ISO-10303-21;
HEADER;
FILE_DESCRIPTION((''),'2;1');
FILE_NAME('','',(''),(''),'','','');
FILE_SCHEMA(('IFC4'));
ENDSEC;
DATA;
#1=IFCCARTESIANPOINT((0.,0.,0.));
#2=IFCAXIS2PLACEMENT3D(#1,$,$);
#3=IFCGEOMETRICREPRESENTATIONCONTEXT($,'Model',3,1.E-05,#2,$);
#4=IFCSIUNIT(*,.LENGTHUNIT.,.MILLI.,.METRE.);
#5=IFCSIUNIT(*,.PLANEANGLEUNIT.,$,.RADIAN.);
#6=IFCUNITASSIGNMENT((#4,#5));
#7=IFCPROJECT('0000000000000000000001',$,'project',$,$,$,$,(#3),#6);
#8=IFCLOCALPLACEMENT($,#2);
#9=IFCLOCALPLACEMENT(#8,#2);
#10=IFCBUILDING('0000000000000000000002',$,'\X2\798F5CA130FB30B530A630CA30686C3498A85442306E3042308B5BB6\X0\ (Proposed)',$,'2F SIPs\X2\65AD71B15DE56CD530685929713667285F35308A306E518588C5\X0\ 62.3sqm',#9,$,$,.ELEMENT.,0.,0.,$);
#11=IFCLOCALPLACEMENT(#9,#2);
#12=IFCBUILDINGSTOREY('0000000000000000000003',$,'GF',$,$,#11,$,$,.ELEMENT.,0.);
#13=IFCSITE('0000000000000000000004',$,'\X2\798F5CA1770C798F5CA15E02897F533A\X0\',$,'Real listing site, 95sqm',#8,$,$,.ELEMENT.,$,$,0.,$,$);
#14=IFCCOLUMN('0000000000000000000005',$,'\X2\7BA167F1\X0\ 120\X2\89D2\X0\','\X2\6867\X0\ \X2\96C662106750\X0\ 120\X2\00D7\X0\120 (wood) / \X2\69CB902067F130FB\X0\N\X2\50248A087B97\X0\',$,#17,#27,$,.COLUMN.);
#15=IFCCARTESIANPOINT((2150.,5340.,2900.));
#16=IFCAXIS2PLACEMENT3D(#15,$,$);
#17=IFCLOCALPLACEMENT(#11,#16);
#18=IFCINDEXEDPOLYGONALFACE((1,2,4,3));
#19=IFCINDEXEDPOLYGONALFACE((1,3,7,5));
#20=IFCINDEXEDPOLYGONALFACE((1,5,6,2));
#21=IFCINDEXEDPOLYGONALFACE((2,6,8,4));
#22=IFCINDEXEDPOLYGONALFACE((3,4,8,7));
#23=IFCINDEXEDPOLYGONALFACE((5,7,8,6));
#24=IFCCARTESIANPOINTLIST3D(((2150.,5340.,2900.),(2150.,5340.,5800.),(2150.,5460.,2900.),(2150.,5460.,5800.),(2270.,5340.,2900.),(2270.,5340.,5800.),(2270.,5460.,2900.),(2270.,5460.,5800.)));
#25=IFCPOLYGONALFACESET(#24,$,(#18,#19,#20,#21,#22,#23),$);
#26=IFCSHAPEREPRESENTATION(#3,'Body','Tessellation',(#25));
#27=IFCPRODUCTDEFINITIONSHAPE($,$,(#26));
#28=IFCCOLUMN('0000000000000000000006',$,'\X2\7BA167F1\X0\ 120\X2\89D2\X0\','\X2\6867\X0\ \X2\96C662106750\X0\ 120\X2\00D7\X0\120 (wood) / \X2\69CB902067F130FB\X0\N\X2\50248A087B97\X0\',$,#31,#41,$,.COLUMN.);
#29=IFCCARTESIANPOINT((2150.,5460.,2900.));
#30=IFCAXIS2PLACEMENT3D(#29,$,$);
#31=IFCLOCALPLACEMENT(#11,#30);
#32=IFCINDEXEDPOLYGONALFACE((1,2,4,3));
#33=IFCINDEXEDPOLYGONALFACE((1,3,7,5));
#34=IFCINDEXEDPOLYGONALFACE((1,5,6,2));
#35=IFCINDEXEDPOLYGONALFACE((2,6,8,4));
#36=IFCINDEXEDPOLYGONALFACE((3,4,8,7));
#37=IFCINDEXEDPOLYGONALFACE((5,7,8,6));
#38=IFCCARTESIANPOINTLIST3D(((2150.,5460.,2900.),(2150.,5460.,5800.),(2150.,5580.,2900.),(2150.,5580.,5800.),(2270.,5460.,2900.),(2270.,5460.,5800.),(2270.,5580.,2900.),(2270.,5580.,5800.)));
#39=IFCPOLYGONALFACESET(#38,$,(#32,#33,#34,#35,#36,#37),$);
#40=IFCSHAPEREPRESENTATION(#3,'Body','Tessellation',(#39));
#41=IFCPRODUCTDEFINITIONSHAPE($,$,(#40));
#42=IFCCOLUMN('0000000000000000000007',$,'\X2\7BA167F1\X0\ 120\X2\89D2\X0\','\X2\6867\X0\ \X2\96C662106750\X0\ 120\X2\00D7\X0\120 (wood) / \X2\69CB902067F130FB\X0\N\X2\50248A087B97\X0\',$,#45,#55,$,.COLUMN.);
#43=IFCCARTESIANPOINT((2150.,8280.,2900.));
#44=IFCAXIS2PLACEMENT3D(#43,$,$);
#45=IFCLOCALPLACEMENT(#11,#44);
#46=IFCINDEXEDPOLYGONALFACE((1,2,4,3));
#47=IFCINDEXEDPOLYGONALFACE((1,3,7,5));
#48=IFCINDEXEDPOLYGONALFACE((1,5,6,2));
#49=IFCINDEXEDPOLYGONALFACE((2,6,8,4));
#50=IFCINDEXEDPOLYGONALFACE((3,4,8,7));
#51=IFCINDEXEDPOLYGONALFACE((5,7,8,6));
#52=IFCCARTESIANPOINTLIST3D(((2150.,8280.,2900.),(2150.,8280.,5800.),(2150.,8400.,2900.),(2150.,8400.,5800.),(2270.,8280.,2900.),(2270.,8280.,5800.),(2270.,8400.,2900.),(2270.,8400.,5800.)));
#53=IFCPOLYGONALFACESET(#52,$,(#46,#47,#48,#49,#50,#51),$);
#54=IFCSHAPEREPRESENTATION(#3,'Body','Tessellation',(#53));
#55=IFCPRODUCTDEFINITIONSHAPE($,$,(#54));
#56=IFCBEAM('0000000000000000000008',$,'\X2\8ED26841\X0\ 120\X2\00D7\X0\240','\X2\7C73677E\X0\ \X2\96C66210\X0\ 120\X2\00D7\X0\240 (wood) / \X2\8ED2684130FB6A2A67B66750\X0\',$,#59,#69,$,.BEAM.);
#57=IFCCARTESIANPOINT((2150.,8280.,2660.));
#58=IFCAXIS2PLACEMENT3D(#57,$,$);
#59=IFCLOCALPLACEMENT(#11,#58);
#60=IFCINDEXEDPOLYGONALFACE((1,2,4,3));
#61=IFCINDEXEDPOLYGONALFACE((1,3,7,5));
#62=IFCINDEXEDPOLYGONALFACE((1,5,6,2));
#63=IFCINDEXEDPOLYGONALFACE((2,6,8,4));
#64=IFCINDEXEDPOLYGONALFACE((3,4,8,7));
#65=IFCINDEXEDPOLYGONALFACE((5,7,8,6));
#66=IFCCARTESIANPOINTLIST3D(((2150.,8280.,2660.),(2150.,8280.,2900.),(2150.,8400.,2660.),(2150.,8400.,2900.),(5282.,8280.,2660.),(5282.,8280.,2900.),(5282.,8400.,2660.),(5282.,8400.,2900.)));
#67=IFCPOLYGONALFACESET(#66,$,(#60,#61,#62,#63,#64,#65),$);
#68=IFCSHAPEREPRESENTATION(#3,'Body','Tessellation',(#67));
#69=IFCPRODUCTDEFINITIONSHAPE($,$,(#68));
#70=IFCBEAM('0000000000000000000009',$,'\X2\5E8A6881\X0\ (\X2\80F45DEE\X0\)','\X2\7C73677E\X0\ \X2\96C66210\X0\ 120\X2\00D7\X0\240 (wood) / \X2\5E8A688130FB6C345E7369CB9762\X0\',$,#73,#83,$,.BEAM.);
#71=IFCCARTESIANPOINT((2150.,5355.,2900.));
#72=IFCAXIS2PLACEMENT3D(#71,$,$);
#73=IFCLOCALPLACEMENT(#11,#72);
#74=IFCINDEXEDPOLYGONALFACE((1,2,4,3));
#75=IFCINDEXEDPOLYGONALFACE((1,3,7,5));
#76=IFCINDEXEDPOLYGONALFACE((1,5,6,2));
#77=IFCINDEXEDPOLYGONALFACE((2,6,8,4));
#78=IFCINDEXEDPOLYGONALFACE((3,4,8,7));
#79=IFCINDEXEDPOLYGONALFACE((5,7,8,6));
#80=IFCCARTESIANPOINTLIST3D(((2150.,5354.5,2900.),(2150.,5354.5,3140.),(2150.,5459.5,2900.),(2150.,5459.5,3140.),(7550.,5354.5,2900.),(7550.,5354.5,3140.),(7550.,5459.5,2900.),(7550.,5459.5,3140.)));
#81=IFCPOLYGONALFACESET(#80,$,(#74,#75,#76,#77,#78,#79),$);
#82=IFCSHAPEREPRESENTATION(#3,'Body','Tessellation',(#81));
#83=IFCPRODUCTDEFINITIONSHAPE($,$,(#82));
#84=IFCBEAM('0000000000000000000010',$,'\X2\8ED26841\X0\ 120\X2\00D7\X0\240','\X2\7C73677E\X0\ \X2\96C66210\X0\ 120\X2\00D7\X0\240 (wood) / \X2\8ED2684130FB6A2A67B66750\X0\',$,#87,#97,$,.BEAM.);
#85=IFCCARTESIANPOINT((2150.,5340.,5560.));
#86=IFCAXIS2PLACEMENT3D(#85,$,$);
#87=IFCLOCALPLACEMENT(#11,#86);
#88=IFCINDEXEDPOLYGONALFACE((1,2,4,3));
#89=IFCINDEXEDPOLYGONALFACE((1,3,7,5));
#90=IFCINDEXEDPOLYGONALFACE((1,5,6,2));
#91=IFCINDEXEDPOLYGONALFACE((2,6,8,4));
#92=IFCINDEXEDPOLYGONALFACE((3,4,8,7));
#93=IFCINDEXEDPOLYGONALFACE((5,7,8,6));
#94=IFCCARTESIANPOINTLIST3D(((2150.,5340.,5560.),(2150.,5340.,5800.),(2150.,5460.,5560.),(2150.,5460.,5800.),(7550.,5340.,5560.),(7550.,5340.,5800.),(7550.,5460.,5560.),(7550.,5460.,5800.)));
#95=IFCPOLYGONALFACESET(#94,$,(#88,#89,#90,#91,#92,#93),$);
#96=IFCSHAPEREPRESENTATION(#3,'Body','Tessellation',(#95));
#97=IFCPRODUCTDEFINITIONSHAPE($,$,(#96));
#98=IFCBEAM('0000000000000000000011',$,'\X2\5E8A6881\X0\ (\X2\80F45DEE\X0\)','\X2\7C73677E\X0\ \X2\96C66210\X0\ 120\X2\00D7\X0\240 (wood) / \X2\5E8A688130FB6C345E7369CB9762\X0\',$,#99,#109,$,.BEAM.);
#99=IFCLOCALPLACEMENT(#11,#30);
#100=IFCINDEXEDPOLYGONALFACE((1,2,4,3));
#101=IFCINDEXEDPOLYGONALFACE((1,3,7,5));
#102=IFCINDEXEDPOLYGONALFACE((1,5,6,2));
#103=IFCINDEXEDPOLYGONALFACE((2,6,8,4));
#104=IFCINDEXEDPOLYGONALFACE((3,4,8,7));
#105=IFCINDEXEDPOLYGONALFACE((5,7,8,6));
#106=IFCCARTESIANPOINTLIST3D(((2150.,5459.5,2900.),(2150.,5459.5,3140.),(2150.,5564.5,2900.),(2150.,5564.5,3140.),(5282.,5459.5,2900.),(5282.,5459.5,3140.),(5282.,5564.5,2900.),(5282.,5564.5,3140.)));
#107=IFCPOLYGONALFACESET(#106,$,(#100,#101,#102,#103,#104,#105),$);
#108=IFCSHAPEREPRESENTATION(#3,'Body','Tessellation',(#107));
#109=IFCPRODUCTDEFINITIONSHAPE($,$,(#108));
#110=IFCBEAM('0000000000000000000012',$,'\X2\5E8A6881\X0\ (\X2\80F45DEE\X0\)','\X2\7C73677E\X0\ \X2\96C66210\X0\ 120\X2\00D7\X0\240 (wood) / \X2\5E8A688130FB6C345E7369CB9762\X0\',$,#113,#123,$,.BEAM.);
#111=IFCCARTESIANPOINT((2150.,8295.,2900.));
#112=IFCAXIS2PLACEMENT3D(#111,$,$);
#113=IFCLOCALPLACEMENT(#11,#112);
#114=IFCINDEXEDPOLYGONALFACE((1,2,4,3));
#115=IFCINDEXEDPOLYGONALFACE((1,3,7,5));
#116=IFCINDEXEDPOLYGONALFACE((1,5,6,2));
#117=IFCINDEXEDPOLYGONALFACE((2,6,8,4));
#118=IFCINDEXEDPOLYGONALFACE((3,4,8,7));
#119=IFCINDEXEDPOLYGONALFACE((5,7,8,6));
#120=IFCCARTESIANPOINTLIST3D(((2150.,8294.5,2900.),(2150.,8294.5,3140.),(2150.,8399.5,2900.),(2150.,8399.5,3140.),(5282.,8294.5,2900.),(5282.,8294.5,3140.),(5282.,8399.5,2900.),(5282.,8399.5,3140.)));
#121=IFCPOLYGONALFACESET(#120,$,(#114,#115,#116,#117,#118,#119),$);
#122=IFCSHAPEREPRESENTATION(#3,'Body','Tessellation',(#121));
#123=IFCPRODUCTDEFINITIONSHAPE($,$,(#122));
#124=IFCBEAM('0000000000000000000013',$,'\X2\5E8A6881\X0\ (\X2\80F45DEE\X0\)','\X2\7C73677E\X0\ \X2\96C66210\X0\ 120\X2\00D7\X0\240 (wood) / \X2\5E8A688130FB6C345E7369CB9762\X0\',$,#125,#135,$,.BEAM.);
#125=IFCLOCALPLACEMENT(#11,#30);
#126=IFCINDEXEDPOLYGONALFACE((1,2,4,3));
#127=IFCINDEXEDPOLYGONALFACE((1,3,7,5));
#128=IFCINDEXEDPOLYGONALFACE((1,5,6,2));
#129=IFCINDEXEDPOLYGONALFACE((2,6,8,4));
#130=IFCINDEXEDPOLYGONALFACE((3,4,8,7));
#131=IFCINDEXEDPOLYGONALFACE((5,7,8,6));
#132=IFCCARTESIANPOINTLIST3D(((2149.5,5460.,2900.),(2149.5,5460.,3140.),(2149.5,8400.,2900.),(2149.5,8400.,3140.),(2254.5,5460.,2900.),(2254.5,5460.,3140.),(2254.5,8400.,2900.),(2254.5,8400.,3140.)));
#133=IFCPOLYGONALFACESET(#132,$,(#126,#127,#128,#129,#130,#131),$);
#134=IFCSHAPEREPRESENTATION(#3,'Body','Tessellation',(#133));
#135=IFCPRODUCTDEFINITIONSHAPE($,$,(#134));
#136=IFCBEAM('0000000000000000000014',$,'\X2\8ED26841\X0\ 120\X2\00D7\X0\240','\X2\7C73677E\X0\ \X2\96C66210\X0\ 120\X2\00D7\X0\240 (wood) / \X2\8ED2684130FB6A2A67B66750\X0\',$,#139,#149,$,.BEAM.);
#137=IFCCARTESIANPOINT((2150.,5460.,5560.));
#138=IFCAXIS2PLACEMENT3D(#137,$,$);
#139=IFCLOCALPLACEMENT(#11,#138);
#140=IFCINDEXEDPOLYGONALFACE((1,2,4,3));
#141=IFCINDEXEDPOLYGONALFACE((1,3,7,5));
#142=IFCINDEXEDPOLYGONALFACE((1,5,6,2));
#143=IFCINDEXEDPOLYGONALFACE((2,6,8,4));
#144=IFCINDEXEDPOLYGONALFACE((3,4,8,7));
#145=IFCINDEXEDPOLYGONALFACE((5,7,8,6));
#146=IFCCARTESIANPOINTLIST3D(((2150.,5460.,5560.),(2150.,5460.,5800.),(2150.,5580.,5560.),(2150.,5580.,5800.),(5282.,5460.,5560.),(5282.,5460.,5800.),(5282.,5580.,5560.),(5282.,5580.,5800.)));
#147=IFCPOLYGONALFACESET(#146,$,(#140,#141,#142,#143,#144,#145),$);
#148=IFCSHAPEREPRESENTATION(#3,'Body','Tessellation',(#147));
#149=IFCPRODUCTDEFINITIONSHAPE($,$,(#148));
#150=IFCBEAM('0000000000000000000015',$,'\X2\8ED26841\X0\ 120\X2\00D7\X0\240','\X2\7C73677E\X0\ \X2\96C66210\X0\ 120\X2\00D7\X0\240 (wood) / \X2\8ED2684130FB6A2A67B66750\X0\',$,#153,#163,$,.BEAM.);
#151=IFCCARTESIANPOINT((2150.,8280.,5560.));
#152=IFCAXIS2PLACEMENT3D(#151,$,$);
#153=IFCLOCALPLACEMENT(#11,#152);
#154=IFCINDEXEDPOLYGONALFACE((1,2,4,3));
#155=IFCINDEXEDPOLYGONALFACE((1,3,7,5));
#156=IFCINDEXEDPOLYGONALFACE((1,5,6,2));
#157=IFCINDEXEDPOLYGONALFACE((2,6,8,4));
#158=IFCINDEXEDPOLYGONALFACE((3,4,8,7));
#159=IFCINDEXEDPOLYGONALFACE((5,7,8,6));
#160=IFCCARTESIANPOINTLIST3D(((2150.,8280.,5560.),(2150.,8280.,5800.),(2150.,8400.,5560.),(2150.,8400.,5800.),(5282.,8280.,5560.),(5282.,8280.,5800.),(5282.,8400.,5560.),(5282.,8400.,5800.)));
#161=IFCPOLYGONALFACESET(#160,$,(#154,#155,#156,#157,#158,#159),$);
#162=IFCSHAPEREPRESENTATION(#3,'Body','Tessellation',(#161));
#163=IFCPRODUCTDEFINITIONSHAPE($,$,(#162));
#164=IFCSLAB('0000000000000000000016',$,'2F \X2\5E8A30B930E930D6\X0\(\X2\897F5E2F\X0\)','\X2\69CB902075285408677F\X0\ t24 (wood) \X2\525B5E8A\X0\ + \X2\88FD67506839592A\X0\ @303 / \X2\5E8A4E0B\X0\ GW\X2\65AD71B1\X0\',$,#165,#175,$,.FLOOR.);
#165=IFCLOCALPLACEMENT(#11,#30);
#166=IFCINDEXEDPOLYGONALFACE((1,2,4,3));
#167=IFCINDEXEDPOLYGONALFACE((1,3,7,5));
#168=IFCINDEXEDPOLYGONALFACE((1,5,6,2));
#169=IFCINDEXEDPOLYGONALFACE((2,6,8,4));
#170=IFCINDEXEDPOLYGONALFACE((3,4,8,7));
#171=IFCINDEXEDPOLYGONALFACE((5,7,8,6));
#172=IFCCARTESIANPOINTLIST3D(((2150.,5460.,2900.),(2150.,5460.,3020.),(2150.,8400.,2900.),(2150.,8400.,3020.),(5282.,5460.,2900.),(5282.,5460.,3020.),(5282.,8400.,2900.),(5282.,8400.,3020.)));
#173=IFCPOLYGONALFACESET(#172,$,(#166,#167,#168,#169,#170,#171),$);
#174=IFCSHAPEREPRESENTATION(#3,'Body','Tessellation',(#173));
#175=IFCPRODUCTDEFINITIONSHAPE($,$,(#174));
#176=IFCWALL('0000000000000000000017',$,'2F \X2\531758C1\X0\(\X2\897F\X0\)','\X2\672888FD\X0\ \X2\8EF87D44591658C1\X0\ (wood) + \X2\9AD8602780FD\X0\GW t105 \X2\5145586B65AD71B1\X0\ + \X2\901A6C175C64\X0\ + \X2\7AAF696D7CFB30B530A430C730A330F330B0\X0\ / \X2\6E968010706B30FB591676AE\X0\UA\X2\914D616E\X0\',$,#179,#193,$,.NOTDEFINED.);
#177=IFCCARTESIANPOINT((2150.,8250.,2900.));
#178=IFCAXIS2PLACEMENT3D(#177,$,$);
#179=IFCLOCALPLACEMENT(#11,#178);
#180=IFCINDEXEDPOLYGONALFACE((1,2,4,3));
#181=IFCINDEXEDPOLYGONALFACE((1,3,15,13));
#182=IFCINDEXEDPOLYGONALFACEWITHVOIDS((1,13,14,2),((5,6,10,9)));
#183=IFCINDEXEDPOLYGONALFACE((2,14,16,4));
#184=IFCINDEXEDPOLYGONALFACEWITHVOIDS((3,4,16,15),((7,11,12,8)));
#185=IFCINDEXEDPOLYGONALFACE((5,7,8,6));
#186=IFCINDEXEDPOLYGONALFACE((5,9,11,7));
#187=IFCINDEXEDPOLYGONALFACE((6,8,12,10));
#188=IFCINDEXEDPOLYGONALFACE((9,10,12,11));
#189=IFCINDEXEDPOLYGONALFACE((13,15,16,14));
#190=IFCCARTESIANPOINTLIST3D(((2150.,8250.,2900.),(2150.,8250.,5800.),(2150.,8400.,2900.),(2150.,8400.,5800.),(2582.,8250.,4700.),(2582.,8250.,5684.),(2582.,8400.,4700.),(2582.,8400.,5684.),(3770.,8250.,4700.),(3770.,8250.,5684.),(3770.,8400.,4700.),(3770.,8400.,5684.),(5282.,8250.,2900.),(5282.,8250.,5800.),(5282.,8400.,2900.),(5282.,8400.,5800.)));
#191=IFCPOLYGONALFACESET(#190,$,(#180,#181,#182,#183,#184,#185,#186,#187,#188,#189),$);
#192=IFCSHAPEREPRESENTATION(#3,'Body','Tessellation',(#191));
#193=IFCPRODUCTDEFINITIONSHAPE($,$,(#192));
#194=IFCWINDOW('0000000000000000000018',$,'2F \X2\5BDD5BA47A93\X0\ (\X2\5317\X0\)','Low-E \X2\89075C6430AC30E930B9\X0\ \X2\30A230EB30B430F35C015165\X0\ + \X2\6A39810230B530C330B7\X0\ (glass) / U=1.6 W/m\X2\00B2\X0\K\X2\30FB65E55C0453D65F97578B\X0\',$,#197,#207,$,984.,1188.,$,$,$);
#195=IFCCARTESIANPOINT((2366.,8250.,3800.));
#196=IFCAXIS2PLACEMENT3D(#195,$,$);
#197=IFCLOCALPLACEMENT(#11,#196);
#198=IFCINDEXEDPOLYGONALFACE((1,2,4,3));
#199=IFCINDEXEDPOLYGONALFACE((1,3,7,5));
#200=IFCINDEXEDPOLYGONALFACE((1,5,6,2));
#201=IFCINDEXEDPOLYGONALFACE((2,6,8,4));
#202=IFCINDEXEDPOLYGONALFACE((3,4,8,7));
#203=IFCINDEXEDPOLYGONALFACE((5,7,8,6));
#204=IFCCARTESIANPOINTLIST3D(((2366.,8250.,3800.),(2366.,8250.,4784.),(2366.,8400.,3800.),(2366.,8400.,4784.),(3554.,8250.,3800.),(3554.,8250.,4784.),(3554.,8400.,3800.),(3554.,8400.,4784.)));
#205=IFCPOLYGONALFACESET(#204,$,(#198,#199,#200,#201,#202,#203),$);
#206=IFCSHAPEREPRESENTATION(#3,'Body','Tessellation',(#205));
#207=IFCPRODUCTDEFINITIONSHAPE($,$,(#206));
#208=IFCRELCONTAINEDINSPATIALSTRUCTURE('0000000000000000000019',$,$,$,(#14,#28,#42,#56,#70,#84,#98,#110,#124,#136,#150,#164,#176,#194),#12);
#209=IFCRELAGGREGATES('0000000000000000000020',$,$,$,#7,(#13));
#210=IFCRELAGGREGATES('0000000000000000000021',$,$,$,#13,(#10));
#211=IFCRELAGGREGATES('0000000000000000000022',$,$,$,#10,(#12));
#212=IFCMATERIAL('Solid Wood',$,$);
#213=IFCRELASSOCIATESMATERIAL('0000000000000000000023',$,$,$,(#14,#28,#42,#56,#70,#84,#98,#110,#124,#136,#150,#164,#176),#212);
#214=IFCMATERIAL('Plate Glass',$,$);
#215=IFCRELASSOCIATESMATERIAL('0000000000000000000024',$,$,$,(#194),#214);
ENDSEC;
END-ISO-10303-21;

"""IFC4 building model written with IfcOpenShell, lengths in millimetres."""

from ifc_helpers import new_model, si_unit, frame, frame_2d, origin, place, context, project, spatial, rectangle, extrude, material, element, fill, save


model = new_model("IFC4")

# Units and contexts
model_context = context("Model", 3, precision=1e-05, world=origin())
ifc_project = project(units=[si_unit("LENGTHUNIT", "METRE", prefix="MILLI"), si_unit("PLANEANGLEUNIT", "RADIAN")], contexts=[model_context])

# Site, building, storey
site_placement = place(None, origin())
site = spatial("IfcSite", under=ifc_project, at=site_placement, Name="福岡県福岡市西区", ObjectType="Real listing site, 95sqm", CompositionType="ELEMENT", RefElevation=0.0)
building_placement = place(site_placement, origin())
building = spatial("IfcBuilding", under=site, at=building_placement, Name="福岡・サウナと水風呂のある家 (Proposed)", ObjectType="2F SIPs断熱工法と天然木張りの内装 62.3sqm", CompositionType="ELEMENT", ElevationOfRefHeight=0.0, ElevationOfTerrain=0.0)
storey_placement = place(building_placement, origin())
storey = spatial("IfcBuildingStorey", under=building, at=storey_placement, Name="GF", CompositionType="ELEMENT", Elevation=0.0)

# Columns
ifc_material_1 = material(Name="Solid Wood")
column_1_placement = place(storey_placement, frame((2150.0, 5340.0, 2900.0)))
element("IfcColumn", 1, at=column_1_placement, inside=storey, material=ifc_material_1, Name="管柱 120角", Description="桧 集成材 120×120 (wood) / 構造柱・N値計算", PredefinedType="COLUMN", context=model_context, shape_type="SweptSolid", body=[
    extrude(rectangle(XDim=120.0, YDim=120.0, at=frame_2d((60.0, 60.0))), frame((2150.0, 5340.0, 2900.0)), (0.0, 0.0, 1.0), 2900.0),
])
column_2_placement = place(storey_placement, frame((2150.0, 5460.0, 2900.0)))
element("IfcColumn", 2, at=column_2_placement, inside=storey, material=ifc_material_1, Name="管柱 120角", Description="桧 集成材 120×120 (wood) / 構造柱・N値計算", PredefinedType="COLUMN", context=model_context, shape_type="SweptSolid", body=[
    extrude(rectangle(XDim=120.0, YDim=120.0, at=frame_2d((60.0, 60.0))), frame((2150.0, 5460.0, 2900.0)), (0.0, 0.0, 1.0), 2900.0),
])
column_3_placement = place(storey_placement, frame((2150.0, 8280.0, 2900.0)))
element("IfcColumn", 3, at=column_3_placement, inside=storey, material=ifc_material_1, Name="管柱 120角", Description="桧 集成材 120×120 (wood) / 構造柱・N値計算", PredefinedType="COLUMN", context=model_context, shape_type="SweptSolid", body=[
    extrude(rectangle(XDim=120.0, YDim=120.0, at=frame_2d((60.0, 60.0))), frame((2150.0, 8280.0, 2900.0)), (0.0, 0.0, 1.0), 2900.0),
])

# Beams
beam_1_placement = place(storey_placement, frame((2150.0, 8280.0, 2660.0)))
element("IfcBeam", 4, at=beam_1_placement, inside=storey, material=ifc_material_1, Name="軒桁 120×240", Description="米松 集成 120×240 (wood) / 軒桁・横架材", PredefinedType="BEAM", context=model_context, shape_type="SweptSolid", body=[
    extrude(rectangle(XDim=3132.0, YDim=120.0, at=frame_2d((1566.0, 60.0))), frame((2150.0, 8280.0, 2660.0)), (0.0, 0.0, 1.0), 240.0),
])
beam_2_placement = place(storey_placement, frame((2150.0, 5355.0, 2900.0)))
element("IfcBeam", 5, at=beam_2_placement, inside=storey, material=ifc_material_1, Name="床梁 (胴差)", Description="米松 集成 120×240 (wood) / 床梁・水平構面", PredefinedType="BEAM", context=model_context, shape_type="SweptSolid", body=[
    extrude(rectangle(XDim=5400.0, YDim=105.0, at=frame_2d((2700.0, 52.0))), frame((2150.0, 5355.0, 2900.0)), (0.0, 0.0, 1.0), 240.0),
])
beam_3_placement = place(storey_placement, frame((2150.0, 5340.0, 5560.0)))
element("IfcBeam", 6, at=beam_3_placement, inside=storey, material=ifc_material_1, Name="軒桁 120×240", Description="米松 集成 120×240 (wood) / 軒桁・横架材", PredefinedType="BEAM", context=model_context, shape_type="SweptSolid", body=[
    extrude(rectangle(XDim=5400.0, YDim=120.0, at=frame_2d((2700.0, 60.0))), frame((2150.0, 5340.0, 5560.0)), (0.0, 0.0, 1.0), 240.0),
])
beam_4_placement = place(storey_placement, frame((2150.0, 5460.0, 2900.0)))
element("IfcBeam", 7, at=beam_4_placement, inside=storey, material=ifc_material_1, Name="床梁 (胴差)", Description="米松 集成 120×240 (wood) / 床梁・水平構面", PredefinedType="BEAM", context=model_context, shape_type="SweptSolid", body=[
    extrude(rectangle(XDim=3132.0, YDim=105.0, at=frame_2d((1566.0, 52.0))), frame((2150.0, 5460.0, 2900.0)), (0.0, 0.0, 1.0), 240.0),
])
beam_5_placement = place(storey_placement, frame((2150.0, 8295.0, 2900.0)))
element("IfcBeam", 8, at=beam_5_placement, inside=storey, material=ifc_material_1, Name="床梁 (胴差)", Description="米松 集成 120×240 (wood) / 床梁・水平構面", PredefinedType="BEAM", context=model_context, shape_type="SweptSolid", body=[
    extrude(rectangle(XDim=3132.0, YDim=105.0, at=frame_2d((1566.0, 52.0))), frame((2150.0, 8295.0, 2900.0)), (0.0, 0.0, 1.0), 240.0),
])
beam_6_placement = place(storey_placement, frame((2150.0, 5460.0, 2900.0)))
element("IfcBeam", 9, at=beam_6_placement, inside=storey, material=ifc_material_1, Name="床梁 (胴差)", Description="米松 集成 120×240 (wood) / 床梁・水平構面", PredefinedType="BEAM", context=model_context, shape_type="SweptSolid", body=[
    extrude(rectangle(XDim=105.0, YDim=2940.0, at=frame_2d((52.0, 1470.0))), frame((2150.0, 5460.0, 2900.0)), (0.0, 0.0, 1.0), 240.0),
])
beam_7_placement = place(storey_placement, frame((2150.0, 5460.0, 5560.0)))
element("IfcBeam", 10, at=beam_7_placement, inside=storey, material=ifc_material_1, Name="軒桁 120×240", Description="米松 集成 120×240 (wood) / 軒桁・横架材", PredefinedType="BEAM", context=model_context, shape_type="SweptSolid", body=[
    extrude(rectangle(XDim=3132.0, YDim=120.0, at=frame_2d((1566.0, 60.0))), frame((2150.0, 5460.0, 5560.0)), (0.0, 0.0, 1.0), 240.0),
])
beam_8_placement = place(storey_placement, frame((2150.0, 8280.0, 5560.0)))
element("IfcBeam", 11, at=beam_8_placement, inside=storey, material=ifc_material_1, Name="軒桁 120×240", Description="米松 集成 120×240 (wood) / 軒桁・横架材", PredefinedType="BEAM", context=model_context, shape_type="SweptSolid", body=[
    extrude(rectangle(XDim=3132.0, YDim=120.0, at=frame_2d((1566.0, 60.0))), frame((2150.0, 8280.0, 5560.0)), (0.0, 0.0, 1.0), 240.0),
])

# Slab
slab_placement = place(storey_placement, frame((2150.0, 5460.0, 2900.0)))
element("IfcSlab", 12, at=slab_placement, inside=storey, material=ifc_material_1, Name="2F 床スラブ(西帯)", Description="構造用合板 t24 (wood) 剛床 + 製材根太 @303 / 床下 GW断熱", PredefinedType="FLOOR", context=model_context, shape_type="SweptSolid", body=[
    extrude(rectangle(XDim=3132.0, YDim=2940.0, at=frame_2d((1566.0, 1470.0))), frame((2150.0, 5460.0, 2900.0)), (0.0, 0.0, 1.0), 120.0),
])

# Wall, opening, window
wall_1_placement = place(storey_placement, frame((2150.0, 8250.0, 2900.0)))
wall_1 = element("IfcWall", 13, at=wall_1_placement, inside=storey, material=ifc_material_1, Name="2F 北壁(西)", Description="木製 軸組外壁 (wood) + 高性能GW t105 充填断熱 + 通気層 + 窯業系サイディング / 準耐火・外皮UA配慮", PredefinedType="NOTDEFINED", context=model_context, shape_type="SweptSolid", body=[
    extrude(rectangle(XDim=3132.0, YDim=150.0, at=frame_2d((1566.0, 75.0))), frame((2150.0, 8250.0, 2900.0)), (0.0, 0.0, 1.0), 2900.0),
])
opening_placement = place(storey_placement, frame((2366.0, 8250.0, 3800.0)))
opening = element("IfcOpeningElement", 14, at=opening_placement, cuts=wall_1, PredefinedType="NOTDEFINED", context=model_context, shape_type="SweptSolid", body=[
    extrude(rectangle(XDim=1188.0, YDim=150.0, at=frame_2d((594.0, 75.0))), frame((2366.0, 8250.0, 3800.0)), (0.0, 0.0, 1.0), 984.0),
])
ifc_material_2 = material(Name="Plate Glass")
window_placement = place(storey_placement, frame((2366.0, 8250.0, 3800.0)))
window = element("IfcWindow", 15, at=window_placement, inside=storey, material=ifc_material_2, Name="2F 寝室窓 (北)", Description="Low-E 複層ガラス アルゴン封入 + 樹脂サッシ (glass) / U=1.6 W/m²K・日射取得型", OverallHeight=984.0, OverallWidth=1188.0, context=model_context, shape_type="SweptSolid", body=[
    extrude(rectangle(XDim=1188.0, YDim=150.0, at=frame_2d((594.0, 75.0))), frame((2366.0, 8250.0, 3800.0)), (0.0, 0.0, 1.0), 984.0),
])
fill(opening, window)

save(model, "model.ifc")
